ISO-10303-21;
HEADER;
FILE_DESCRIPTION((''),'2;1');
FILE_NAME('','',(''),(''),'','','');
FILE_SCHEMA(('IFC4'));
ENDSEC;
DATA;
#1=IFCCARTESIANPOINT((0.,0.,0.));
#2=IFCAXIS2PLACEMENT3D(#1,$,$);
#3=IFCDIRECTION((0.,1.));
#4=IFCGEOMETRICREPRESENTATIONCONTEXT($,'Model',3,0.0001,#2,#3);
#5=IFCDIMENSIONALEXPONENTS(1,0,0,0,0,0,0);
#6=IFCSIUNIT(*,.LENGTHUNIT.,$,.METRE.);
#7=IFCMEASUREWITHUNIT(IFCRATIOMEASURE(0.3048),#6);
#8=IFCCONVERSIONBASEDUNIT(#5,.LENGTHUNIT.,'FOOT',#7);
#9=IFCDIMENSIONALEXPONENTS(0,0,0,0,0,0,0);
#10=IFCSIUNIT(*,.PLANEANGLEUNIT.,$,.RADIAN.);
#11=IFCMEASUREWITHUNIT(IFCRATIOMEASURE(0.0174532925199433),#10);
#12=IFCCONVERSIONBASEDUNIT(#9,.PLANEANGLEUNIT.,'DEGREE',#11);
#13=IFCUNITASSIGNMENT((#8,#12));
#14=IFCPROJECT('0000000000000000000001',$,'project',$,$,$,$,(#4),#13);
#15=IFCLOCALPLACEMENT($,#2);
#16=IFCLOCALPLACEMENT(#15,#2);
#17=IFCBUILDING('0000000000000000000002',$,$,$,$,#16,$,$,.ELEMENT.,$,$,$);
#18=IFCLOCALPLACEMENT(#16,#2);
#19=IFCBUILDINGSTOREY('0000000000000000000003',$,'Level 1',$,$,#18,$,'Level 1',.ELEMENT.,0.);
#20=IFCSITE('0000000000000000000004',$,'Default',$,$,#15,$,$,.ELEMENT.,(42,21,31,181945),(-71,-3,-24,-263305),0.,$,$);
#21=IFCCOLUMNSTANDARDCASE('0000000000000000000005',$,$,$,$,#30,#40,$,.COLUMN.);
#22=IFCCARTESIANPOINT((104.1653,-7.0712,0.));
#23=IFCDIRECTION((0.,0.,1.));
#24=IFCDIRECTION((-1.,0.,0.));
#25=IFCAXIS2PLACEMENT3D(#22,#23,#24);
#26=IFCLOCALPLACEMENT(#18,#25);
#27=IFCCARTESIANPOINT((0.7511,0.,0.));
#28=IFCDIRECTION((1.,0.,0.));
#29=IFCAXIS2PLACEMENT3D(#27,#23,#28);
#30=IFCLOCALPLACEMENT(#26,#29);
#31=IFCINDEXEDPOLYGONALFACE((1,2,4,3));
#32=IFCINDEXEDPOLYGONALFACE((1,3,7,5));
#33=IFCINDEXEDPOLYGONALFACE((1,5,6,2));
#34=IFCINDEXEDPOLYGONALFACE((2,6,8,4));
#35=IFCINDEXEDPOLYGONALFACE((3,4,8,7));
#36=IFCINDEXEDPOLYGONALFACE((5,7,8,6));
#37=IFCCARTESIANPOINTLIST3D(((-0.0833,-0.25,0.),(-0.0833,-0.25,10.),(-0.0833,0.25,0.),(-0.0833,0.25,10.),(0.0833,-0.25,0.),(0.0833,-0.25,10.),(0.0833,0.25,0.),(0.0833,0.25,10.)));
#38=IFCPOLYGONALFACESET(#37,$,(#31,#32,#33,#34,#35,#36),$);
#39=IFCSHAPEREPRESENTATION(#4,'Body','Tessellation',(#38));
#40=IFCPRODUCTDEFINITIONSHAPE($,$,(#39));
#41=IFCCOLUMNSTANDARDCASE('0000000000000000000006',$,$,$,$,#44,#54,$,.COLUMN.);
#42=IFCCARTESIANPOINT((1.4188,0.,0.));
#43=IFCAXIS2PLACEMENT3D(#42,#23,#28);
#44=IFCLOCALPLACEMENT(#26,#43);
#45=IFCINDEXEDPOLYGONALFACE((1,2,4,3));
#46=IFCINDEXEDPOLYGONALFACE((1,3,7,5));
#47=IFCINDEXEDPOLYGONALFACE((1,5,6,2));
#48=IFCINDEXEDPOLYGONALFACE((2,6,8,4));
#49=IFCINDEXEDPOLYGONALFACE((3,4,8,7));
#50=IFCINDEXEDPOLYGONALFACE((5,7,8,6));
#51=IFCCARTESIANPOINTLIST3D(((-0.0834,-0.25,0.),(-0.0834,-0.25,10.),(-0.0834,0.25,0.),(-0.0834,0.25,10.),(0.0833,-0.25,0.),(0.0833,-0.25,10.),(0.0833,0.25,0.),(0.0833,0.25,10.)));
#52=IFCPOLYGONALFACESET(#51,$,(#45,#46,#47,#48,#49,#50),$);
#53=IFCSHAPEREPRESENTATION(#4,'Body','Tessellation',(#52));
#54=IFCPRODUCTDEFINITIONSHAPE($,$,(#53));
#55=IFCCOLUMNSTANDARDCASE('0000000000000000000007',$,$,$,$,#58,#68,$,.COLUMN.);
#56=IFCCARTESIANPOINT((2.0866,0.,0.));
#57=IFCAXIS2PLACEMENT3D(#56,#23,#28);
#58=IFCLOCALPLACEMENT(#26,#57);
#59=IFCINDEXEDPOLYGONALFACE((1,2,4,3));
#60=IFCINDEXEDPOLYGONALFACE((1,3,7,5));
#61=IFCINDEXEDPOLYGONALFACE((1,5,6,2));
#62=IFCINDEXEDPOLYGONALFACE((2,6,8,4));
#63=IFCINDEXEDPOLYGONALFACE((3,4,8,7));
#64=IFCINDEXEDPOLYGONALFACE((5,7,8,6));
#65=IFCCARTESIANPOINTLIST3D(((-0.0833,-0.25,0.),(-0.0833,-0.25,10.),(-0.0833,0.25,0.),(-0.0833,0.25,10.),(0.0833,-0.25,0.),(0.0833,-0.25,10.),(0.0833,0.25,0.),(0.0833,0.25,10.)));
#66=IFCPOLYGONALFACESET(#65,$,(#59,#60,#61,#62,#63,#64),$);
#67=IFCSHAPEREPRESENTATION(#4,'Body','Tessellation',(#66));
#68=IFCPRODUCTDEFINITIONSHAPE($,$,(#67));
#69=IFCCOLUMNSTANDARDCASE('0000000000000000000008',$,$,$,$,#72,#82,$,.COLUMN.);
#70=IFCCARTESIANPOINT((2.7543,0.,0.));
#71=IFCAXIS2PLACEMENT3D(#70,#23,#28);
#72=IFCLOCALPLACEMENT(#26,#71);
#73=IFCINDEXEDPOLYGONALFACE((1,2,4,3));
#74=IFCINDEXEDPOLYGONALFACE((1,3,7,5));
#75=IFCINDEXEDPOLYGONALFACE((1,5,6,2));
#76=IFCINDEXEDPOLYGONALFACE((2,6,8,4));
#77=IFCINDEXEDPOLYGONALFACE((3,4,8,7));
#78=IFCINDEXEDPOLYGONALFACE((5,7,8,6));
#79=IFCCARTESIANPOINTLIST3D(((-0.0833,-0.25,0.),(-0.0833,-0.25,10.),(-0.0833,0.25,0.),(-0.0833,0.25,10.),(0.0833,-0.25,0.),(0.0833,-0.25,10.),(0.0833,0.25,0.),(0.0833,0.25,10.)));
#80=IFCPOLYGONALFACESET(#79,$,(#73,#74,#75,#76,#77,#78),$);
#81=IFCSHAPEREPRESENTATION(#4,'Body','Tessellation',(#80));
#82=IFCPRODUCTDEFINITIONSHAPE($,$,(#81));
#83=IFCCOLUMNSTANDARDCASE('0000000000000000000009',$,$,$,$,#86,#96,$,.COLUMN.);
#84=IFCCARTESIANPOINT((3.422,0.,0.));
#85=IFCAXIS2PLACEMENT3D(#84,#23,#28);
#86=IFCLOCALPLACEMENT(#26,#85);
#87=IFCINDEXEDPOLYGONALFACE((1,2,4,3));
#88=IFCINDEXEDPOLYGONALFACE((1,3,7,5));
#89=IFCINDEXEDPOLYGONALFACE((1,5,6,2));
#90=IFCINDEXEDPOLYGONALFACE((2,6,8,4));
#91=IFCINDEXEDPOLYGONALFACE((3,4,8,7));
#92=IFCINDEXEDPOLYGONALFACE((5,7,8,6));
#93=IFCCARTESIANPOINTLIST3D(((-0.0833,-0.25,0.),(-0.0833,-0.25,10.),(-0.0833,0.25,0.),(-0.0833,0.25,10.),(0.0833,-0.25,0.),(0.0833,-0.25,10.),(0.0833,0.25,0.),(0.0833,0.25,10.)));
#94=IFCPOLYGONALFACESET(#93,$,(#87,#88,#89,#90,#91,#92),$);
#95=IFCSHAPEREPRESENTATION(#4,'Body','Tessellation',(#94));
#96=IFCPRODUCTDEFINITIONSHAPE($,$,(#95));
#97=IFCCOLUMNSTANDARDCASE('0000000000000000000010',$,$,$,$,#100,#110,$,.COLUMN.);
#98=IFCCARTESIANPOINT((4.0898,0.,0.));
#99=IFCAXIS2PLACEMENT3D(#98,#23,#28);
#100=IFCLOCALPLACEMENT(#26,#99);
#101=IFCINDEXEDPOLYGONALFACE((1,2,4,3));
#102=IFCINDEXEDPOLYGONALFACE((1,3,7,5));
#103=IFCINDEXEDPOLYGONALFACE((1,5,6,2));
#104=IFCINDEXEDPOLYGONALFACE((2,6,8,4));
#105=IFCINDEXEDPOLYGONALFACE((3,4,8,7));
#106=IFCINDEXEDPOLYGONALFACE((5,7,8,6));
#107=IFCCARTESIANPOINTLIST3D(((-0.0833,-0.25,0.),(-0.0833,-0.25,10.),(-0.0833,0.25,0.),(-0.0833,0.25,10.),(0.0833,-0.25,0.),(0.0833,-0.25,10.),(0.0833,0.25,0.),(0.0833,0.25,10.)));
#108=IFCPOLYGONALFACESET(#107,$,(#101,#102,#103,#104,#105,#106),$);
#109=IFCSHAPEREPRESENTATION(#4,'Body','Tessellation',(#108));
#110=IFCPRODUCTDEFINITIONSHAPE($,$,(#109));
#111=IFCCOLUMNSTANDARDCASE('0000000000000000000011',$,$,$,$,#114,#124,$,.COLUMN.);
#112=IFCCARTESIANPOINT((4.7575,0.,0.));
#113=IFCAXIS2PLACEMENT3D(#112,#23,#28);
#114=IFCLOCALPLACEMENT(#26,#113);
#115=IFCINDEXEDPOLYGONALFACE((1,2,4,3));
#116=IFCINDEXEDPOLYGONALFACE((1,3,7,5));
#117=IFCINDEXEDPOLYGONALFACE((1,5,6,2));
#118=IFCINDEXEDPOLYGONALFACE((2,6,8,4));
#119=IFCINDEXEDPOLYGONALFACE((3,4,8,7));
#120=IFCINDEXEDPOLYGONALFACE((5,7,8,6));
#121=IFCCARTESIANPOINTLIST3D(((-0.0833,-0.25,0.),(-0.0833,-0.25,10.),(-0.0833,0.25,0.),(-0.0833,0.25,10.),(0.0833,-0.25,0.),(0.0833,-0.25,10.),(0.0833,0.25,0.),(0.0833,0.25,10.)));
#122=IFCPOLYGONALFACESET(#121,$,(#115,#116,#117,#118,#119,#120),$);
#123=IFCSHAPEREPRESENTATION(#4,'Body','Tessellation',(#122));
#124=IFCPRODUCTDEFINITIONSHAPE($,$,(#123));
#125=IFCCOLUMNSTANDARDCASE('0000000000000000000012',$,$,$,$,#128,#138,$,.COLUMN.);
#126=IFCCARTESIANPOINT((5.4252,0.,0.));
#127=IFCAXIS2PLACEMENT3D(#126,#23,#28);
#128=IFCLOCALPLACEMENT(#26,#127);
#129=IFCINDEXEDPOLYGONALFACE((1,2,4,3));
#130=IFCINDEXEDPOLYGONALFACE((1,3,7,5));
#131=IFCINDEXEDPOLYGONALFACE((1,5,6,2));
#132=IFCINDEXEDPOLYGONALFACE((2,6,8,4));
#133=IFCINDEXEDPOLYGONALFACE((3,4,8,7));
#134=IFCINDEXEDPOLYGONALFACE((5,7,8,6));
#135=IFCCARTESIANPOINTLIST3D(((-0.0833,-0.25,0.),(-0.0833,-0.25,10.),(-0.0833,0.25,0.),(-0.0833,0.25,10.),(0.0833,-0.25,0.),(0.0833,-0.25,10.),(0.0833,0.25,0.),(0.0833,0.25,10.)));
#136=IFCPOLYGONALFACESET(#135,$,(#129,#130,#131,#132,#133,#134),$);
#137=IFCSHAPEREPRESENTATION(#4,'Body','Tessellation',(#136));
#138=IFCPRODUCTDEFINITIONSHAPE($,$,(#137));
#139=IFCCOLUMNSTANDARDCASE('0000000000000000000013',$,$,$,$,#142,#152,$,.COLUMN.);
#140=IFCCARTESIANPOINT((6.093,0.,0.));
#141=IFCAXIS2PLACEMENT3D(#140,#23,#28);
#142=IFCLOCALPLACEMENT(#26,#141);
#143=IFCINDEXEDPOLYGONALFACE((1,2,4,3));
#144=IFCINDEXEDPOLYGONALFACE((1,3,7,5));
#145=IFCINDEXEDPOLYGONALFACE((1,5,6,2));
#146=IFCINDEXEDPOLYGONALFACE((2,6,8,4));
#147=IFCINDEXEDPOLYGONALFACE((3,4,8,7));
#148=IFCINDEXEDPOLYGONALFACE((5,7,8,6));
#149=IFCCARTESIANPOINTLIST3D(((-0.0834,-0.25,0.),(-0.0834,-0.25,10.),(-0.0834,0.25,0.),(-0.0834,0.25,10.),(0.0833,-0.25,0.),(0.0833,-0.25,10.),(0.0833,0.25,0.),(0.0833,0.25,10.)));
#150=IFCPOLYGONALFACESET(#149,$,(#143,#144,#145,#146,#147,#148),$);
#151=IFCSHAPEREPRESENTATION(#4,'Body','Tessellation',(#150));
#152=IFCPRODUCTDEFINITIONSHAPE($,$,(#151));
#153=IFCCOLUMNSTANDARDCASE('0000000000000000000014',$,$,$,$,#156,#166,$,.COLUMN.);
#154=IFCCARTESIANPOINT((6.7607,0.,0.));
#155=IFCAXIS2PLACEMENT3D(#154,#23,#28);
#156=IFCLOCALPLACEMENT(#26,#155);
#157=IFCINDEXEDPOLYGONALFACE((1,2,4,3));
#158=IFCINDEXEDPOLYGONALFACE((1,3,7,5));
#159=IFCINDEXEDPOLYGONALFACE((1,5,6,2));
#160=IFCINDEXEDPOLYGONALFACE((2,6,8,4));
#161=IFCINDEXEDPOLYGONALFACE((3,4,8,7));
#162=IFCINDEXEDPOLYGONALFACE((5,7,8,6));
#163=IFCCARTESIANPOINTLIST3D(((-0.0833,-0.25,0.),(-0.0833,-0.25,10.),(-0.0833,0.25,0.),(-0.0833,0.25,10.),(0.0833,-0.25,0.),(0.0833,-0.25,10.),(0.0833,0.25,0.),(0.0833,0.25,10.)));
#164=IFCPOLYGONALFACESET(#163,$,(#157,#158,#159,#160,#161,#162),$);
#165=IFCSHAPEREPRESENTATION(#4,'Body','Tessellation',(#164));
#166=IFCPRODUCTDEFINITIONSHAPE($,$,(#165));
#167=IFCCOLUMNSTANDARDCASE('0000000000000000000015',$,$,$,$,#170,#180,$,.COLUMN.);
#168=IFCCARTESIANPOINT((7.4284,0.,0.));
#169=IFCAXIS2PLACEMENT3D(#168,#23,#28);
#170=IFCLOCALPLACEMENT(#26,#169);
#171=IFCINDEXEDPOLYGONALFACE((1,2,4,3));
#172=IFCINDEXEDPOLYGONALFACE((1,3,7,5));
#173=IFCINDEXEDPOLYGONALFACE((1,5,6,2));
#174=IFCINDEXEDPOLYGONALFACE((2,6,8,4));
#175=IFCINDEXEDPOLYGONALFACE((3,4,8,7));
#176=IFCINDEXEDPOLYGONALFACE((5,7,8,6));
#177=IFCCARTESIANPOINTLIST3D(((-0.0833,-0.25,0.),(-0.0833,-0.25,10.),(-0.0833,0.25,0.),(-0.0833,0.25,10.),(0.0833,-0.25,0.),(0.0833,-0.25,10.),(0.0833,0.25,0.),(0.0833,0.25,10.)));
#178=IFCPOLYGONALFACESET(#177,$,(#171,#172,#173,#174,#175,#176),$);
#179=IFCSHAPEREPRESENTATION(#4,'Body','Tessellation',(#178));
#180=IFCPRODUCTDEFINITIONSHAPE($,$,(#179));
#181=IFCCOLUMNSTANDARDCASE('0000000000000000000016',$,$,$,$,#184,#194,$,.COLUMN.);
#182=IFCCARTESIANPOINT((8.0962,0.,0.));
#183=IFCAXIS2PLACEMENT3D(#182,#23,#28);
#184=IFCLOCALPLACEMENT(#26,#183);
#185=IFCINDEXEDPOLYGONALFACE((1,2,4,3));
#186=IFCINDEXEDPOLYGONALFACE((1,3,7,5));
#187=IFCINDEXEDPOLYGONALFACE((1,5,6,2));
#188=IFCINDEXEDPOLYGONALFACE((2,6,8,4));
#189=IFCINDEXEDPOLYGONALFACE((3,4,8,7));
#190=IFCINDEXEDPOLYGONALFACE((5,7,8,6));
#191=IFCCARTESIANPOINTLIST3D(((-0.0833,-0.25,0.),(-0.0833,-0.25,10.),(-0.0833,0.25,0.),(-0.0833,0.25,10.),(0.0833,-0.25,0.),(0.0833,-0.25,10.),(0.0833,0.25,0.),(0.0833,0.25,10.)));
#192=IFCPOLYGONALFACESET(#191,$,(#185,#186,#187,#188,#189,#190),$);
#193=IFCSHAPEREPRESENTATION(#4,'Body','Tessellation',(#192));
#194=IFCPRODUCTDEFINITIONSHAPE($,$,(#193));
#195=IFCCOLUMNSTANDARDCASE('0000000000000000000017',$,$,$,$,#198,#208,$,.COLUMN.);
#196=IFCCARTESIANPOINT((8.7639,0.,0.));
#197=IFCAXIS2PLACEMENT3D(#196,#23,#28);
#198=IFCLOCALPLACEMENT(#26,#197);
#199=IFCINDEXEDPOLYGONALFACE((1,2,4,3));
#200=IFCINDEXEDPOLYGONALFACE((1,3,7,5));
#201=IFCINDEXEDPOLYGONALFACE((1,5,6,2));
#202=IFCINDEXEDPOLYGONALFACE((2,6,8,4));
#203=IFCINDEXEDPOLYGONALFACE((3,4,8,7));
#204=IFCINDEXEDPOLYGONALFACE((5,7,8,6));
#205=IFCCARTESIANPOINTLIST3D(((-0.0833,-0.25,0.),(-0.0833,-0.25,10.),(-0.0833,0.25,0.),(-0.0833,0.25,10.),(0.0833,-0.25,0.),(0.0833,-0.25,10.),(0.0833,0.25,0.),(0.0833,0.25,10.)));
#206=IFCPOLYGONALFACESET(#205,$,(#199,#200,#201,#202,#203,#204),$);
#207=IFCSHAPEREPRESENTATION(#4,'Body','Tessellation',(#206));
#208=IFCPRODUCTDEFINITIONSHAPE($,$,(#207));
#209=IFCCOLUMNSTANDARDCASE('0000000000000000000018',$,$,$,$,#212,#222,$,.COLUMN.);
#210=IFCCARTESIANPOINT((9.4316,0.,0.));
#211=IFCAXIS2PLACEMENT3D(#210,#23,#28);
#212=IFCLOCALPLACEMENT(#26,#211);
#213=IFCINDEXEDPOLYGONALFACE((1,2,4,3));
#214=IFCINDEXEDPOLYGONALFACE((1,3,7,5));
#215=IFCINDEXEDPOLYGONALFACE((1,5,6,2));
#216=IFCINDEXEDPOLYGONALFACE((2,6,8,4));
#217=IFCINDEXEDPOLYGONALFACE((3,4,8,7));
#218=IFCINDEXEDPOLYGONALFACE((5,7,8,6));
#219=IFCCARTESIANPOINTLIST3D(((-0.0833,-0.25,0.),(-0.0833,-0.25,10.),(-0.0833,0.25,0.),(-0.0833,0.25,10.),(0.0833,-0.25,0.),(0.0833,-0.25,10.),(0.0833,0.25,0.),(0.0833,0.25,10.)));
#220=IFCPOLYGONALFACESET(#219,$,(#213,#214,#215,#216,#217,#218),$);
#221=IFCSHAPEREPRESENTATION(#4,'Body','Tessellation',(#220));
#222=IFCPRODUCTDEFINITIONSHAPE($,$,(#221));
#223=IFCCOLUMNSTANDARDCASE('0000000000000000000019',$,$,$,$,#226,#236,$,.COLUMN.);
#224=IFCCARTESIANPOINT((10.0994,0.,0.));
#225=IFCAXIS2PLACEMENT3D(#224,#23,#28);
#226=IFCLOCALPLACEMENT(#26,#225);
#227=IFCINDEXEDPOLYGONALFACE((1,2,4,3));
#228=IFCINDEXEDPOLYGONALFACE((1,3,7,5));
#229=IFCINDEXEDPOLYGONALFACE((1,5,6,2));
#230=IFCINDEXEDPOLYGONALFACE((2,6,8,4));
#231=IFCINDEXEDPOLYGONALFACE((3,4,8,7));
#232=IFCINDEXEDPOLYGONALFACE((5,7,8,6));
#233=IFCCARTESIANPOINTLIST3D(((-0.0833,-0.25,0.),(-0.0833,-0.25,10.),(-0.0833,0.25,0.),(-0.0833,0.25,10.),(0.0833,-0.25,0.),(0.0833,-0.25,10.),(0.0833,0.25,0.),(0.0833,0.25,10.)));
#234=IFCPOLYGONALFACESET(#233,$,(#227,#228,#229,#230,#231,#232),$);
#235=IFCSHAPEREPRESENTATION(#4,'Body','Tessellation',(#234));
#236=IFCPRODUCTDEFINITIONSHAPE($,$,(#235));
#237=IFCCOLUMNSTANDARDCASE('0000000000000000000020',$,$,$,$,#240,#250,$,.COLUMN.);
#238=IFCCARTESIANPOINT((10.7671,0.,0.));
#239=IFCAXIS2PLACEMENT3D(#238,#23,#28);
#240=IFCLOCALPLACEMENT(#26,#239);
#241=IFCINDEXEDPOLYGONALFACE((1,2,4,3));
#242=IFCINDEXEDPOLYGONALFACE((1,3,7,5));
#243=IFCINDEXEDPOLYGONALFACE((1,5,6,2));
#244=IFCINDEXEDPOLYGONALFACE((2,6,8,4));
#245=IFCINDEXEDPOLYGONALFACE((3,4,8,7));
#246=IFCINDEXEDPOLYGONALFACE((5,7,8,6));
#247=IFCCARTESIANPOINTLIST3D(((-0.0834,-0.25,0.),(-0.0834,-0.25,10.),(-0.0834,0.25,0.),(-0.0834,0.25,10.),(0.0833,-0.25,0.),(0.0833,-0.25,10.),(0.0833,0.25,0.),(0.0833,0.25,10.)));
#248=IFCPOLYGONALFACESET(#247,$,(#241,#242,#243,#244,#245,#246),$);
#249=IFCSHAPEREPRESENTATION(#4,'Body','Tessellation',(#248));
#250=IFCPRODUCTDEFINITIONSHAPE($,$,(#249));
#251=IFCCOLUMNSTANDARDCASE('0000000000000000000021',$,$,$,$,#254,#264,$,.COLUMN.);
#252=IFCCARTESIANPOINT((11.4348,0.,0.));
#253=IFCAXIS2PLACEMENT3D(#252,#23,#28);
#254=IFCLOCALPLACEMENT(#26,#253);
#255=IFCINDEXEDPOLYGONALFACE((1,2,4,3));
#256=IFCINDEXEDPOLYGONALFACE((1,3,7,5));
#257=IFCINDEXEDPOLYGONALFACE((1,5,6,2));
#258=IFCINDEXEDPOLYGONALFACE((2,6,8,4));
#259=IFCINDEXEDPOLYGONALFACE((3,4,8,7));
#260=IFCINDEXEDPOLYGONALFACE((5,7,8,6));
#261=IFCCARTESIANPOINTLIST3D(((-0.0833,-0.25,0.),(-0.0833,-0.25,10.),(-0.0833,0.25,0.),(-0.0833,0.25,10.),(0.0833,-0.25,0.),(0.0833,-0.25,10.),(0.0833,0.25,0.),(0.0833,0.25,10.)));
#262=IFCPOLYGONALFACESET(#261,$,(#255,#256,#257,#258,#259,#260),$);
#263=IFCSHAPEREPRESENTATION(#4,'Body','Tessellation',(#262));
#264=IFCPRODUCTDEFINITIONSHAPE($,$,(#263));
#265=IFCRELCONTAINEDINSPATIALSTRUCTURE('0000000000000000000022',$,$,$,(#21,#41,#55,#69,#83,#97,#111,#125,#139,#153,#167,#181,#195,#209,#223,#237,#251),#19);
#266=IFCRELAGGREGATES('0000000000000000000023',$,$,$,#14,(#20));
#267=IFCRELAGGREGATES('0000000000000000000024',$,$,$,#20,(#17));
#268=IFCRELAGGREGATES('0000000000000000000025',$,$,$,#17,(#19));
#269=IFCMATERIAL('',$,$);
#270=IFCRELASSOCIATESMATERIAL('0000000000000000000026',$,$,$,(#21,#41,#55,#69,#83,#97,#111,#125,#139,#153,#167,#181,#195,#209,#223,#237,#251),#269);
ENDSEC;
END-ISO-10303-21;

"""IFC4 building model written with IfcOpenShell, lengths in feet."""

from ifc_helpers import new_model, entity, si_unit, converted_unit, direction, frame, origin, place, context, project, spatial, rectangle, extrude, material, element, save


model = new_model("IFC4")

# Units and contexts
model_context = context("Model", 3, precision=0.0001, world=origin(), true_north=direction((0.0, 1.0)))
ifc_project = project(units=[converted_unit("LENGTHUNIT", "FOOT", entity("IfcRatioMeasure", 0.3048), si_unit("LENGTHUNIT", "METRE"), dimensions=[1, 0, 0, 0, 0, 0, 0]), converted_unit("PLANEANGLEUNIT", "DEGREE", entity("IfcRatioMeasure", 0.0174532925199433), si_unit("PLANEANGLEUNIT", "RADIAN"), dimensions=[0, 0, 0, 0, 0, 0, 0])], contexts=[model_context])

# Site, building, storey
site_placement = place(None, origin())
site = spatial("IfcSite", under=ifc_project, at=site_placement, Name="Default", CompositionType="ELEMENT", RefLatitude=(42, 21, 31, 181945), RefLongitude=(-71, -3, -24, -263305), RefElevation=0.0)
building_placement = place(site_placement, origin())
building = spatial("IfcBuilding", under=site, at=building_placement, CompositionType="ELEMENT")
storey_placement = place(building_placement, origin())
storey = spatial("IfcBuildingStorey", under=building, at=storey_placement, Name="Level 1", LongName="Level 1", CompositionType="ELEMENT", Elevation=0.0)

# Columns
ifc_material_1 = material(Name="")
wall_1_placement = place(storey_placement, frame((104.1653, -7.0712, 0.0), z_axis=(0.0, 0.0, 1.0), x_axis=(-1.0, 0.0, 0.0)))
for number, where, z_axis, x_axis in (
    (1, (0.7511, 0.0, 0.0), (0.0, 0.0, 1.0), (1.0, 0.0, 0.0)),
    (2, (1.4188, 0.0, 0.0), (0.0, 0.0, 1.0), (1.0, 0.0, 0.0)),
    (3, (2.0866, 0.0, 0.0), (0.0, 0.0, 1.0), (1.0, 0.0, 0.0)),
    (4, (2.7543, 0.0, 0.0), (0.0, 0.0, 1.0), (1.0, 0.0, 0.0)),
    (5, (3.422, 0.0, 0.0), (0.0, 0.0, 1.0), (1.0, 0.0, 0.0)),
    (6, (4.0898, 0.0, 0.0), (0.0, 0.0, 1.0), (1.0, 0.0, 0.0)),
    (7, (4.7575, 0.0, 0.0), (0.0, 0.0, 1.0), (1.0, 0.0, 0.0)),
    (8, (5.4252, 0.0, 0.0), (0.0, 0.0, 1.0), (1.0, 0.0, 0.0)),
    (9, (6.093, 0.0, 0.0), (0.0, 0.0, 1.0), (1.0, 0.0, 0.0)),
    (10, (6.7607, 0.0, 0.0), (0.0, 0.0, 1.0), (1.0, 0.0, 0.0)),
    (11, (7.4284, 0.0, 0.0), (0.0, 0.0, 1.0), (1.0, 0.0, 0.0)),
    (12, (8.0962, 0.0, 0.0), (0.0, 0.0, 1.0), (1.0, 0.0, 0.0)),
    (13, (8.7639, 0.0, 0.0), (0.0, 0.0, 1.0), (1.0, 0.0, 0.0)),
    (14, (9.4316, 0.0, 0.0), (0.0, 0.0, 1.0), (1.0, 0.0, 0.0)),
    (15, (10.0994, 0.0, 0.0), (0.0, 0.0, 1.0), (1.0, 0.0, 0.0)),
    (16, (10.7671, 0.0, 0.0), (0.0, 0.0, 1.0), (1.0, 0.0, 0.0)),
    (17, (11.4348, 0.0, 0.0), (0.0, 0.0, 1.0), (1.0, 0.0, 0.0)),
):
    element("IfcColumnStandardCase", number, at=place(wall_1_placement, frame(where, z_axis=z_axis, x_axis=x_axis)), inside=storey, material=ifc_material_1, PredefinedType="COLUMN", context=model_context, shape_type="SweptSolid", body=[
        extrude(rectangle(XDim=0.1667, YDim=0.5), origin(), (0.0, 0.0, 1.0), 10.0),
    ])

save(model, "model.ifc")
